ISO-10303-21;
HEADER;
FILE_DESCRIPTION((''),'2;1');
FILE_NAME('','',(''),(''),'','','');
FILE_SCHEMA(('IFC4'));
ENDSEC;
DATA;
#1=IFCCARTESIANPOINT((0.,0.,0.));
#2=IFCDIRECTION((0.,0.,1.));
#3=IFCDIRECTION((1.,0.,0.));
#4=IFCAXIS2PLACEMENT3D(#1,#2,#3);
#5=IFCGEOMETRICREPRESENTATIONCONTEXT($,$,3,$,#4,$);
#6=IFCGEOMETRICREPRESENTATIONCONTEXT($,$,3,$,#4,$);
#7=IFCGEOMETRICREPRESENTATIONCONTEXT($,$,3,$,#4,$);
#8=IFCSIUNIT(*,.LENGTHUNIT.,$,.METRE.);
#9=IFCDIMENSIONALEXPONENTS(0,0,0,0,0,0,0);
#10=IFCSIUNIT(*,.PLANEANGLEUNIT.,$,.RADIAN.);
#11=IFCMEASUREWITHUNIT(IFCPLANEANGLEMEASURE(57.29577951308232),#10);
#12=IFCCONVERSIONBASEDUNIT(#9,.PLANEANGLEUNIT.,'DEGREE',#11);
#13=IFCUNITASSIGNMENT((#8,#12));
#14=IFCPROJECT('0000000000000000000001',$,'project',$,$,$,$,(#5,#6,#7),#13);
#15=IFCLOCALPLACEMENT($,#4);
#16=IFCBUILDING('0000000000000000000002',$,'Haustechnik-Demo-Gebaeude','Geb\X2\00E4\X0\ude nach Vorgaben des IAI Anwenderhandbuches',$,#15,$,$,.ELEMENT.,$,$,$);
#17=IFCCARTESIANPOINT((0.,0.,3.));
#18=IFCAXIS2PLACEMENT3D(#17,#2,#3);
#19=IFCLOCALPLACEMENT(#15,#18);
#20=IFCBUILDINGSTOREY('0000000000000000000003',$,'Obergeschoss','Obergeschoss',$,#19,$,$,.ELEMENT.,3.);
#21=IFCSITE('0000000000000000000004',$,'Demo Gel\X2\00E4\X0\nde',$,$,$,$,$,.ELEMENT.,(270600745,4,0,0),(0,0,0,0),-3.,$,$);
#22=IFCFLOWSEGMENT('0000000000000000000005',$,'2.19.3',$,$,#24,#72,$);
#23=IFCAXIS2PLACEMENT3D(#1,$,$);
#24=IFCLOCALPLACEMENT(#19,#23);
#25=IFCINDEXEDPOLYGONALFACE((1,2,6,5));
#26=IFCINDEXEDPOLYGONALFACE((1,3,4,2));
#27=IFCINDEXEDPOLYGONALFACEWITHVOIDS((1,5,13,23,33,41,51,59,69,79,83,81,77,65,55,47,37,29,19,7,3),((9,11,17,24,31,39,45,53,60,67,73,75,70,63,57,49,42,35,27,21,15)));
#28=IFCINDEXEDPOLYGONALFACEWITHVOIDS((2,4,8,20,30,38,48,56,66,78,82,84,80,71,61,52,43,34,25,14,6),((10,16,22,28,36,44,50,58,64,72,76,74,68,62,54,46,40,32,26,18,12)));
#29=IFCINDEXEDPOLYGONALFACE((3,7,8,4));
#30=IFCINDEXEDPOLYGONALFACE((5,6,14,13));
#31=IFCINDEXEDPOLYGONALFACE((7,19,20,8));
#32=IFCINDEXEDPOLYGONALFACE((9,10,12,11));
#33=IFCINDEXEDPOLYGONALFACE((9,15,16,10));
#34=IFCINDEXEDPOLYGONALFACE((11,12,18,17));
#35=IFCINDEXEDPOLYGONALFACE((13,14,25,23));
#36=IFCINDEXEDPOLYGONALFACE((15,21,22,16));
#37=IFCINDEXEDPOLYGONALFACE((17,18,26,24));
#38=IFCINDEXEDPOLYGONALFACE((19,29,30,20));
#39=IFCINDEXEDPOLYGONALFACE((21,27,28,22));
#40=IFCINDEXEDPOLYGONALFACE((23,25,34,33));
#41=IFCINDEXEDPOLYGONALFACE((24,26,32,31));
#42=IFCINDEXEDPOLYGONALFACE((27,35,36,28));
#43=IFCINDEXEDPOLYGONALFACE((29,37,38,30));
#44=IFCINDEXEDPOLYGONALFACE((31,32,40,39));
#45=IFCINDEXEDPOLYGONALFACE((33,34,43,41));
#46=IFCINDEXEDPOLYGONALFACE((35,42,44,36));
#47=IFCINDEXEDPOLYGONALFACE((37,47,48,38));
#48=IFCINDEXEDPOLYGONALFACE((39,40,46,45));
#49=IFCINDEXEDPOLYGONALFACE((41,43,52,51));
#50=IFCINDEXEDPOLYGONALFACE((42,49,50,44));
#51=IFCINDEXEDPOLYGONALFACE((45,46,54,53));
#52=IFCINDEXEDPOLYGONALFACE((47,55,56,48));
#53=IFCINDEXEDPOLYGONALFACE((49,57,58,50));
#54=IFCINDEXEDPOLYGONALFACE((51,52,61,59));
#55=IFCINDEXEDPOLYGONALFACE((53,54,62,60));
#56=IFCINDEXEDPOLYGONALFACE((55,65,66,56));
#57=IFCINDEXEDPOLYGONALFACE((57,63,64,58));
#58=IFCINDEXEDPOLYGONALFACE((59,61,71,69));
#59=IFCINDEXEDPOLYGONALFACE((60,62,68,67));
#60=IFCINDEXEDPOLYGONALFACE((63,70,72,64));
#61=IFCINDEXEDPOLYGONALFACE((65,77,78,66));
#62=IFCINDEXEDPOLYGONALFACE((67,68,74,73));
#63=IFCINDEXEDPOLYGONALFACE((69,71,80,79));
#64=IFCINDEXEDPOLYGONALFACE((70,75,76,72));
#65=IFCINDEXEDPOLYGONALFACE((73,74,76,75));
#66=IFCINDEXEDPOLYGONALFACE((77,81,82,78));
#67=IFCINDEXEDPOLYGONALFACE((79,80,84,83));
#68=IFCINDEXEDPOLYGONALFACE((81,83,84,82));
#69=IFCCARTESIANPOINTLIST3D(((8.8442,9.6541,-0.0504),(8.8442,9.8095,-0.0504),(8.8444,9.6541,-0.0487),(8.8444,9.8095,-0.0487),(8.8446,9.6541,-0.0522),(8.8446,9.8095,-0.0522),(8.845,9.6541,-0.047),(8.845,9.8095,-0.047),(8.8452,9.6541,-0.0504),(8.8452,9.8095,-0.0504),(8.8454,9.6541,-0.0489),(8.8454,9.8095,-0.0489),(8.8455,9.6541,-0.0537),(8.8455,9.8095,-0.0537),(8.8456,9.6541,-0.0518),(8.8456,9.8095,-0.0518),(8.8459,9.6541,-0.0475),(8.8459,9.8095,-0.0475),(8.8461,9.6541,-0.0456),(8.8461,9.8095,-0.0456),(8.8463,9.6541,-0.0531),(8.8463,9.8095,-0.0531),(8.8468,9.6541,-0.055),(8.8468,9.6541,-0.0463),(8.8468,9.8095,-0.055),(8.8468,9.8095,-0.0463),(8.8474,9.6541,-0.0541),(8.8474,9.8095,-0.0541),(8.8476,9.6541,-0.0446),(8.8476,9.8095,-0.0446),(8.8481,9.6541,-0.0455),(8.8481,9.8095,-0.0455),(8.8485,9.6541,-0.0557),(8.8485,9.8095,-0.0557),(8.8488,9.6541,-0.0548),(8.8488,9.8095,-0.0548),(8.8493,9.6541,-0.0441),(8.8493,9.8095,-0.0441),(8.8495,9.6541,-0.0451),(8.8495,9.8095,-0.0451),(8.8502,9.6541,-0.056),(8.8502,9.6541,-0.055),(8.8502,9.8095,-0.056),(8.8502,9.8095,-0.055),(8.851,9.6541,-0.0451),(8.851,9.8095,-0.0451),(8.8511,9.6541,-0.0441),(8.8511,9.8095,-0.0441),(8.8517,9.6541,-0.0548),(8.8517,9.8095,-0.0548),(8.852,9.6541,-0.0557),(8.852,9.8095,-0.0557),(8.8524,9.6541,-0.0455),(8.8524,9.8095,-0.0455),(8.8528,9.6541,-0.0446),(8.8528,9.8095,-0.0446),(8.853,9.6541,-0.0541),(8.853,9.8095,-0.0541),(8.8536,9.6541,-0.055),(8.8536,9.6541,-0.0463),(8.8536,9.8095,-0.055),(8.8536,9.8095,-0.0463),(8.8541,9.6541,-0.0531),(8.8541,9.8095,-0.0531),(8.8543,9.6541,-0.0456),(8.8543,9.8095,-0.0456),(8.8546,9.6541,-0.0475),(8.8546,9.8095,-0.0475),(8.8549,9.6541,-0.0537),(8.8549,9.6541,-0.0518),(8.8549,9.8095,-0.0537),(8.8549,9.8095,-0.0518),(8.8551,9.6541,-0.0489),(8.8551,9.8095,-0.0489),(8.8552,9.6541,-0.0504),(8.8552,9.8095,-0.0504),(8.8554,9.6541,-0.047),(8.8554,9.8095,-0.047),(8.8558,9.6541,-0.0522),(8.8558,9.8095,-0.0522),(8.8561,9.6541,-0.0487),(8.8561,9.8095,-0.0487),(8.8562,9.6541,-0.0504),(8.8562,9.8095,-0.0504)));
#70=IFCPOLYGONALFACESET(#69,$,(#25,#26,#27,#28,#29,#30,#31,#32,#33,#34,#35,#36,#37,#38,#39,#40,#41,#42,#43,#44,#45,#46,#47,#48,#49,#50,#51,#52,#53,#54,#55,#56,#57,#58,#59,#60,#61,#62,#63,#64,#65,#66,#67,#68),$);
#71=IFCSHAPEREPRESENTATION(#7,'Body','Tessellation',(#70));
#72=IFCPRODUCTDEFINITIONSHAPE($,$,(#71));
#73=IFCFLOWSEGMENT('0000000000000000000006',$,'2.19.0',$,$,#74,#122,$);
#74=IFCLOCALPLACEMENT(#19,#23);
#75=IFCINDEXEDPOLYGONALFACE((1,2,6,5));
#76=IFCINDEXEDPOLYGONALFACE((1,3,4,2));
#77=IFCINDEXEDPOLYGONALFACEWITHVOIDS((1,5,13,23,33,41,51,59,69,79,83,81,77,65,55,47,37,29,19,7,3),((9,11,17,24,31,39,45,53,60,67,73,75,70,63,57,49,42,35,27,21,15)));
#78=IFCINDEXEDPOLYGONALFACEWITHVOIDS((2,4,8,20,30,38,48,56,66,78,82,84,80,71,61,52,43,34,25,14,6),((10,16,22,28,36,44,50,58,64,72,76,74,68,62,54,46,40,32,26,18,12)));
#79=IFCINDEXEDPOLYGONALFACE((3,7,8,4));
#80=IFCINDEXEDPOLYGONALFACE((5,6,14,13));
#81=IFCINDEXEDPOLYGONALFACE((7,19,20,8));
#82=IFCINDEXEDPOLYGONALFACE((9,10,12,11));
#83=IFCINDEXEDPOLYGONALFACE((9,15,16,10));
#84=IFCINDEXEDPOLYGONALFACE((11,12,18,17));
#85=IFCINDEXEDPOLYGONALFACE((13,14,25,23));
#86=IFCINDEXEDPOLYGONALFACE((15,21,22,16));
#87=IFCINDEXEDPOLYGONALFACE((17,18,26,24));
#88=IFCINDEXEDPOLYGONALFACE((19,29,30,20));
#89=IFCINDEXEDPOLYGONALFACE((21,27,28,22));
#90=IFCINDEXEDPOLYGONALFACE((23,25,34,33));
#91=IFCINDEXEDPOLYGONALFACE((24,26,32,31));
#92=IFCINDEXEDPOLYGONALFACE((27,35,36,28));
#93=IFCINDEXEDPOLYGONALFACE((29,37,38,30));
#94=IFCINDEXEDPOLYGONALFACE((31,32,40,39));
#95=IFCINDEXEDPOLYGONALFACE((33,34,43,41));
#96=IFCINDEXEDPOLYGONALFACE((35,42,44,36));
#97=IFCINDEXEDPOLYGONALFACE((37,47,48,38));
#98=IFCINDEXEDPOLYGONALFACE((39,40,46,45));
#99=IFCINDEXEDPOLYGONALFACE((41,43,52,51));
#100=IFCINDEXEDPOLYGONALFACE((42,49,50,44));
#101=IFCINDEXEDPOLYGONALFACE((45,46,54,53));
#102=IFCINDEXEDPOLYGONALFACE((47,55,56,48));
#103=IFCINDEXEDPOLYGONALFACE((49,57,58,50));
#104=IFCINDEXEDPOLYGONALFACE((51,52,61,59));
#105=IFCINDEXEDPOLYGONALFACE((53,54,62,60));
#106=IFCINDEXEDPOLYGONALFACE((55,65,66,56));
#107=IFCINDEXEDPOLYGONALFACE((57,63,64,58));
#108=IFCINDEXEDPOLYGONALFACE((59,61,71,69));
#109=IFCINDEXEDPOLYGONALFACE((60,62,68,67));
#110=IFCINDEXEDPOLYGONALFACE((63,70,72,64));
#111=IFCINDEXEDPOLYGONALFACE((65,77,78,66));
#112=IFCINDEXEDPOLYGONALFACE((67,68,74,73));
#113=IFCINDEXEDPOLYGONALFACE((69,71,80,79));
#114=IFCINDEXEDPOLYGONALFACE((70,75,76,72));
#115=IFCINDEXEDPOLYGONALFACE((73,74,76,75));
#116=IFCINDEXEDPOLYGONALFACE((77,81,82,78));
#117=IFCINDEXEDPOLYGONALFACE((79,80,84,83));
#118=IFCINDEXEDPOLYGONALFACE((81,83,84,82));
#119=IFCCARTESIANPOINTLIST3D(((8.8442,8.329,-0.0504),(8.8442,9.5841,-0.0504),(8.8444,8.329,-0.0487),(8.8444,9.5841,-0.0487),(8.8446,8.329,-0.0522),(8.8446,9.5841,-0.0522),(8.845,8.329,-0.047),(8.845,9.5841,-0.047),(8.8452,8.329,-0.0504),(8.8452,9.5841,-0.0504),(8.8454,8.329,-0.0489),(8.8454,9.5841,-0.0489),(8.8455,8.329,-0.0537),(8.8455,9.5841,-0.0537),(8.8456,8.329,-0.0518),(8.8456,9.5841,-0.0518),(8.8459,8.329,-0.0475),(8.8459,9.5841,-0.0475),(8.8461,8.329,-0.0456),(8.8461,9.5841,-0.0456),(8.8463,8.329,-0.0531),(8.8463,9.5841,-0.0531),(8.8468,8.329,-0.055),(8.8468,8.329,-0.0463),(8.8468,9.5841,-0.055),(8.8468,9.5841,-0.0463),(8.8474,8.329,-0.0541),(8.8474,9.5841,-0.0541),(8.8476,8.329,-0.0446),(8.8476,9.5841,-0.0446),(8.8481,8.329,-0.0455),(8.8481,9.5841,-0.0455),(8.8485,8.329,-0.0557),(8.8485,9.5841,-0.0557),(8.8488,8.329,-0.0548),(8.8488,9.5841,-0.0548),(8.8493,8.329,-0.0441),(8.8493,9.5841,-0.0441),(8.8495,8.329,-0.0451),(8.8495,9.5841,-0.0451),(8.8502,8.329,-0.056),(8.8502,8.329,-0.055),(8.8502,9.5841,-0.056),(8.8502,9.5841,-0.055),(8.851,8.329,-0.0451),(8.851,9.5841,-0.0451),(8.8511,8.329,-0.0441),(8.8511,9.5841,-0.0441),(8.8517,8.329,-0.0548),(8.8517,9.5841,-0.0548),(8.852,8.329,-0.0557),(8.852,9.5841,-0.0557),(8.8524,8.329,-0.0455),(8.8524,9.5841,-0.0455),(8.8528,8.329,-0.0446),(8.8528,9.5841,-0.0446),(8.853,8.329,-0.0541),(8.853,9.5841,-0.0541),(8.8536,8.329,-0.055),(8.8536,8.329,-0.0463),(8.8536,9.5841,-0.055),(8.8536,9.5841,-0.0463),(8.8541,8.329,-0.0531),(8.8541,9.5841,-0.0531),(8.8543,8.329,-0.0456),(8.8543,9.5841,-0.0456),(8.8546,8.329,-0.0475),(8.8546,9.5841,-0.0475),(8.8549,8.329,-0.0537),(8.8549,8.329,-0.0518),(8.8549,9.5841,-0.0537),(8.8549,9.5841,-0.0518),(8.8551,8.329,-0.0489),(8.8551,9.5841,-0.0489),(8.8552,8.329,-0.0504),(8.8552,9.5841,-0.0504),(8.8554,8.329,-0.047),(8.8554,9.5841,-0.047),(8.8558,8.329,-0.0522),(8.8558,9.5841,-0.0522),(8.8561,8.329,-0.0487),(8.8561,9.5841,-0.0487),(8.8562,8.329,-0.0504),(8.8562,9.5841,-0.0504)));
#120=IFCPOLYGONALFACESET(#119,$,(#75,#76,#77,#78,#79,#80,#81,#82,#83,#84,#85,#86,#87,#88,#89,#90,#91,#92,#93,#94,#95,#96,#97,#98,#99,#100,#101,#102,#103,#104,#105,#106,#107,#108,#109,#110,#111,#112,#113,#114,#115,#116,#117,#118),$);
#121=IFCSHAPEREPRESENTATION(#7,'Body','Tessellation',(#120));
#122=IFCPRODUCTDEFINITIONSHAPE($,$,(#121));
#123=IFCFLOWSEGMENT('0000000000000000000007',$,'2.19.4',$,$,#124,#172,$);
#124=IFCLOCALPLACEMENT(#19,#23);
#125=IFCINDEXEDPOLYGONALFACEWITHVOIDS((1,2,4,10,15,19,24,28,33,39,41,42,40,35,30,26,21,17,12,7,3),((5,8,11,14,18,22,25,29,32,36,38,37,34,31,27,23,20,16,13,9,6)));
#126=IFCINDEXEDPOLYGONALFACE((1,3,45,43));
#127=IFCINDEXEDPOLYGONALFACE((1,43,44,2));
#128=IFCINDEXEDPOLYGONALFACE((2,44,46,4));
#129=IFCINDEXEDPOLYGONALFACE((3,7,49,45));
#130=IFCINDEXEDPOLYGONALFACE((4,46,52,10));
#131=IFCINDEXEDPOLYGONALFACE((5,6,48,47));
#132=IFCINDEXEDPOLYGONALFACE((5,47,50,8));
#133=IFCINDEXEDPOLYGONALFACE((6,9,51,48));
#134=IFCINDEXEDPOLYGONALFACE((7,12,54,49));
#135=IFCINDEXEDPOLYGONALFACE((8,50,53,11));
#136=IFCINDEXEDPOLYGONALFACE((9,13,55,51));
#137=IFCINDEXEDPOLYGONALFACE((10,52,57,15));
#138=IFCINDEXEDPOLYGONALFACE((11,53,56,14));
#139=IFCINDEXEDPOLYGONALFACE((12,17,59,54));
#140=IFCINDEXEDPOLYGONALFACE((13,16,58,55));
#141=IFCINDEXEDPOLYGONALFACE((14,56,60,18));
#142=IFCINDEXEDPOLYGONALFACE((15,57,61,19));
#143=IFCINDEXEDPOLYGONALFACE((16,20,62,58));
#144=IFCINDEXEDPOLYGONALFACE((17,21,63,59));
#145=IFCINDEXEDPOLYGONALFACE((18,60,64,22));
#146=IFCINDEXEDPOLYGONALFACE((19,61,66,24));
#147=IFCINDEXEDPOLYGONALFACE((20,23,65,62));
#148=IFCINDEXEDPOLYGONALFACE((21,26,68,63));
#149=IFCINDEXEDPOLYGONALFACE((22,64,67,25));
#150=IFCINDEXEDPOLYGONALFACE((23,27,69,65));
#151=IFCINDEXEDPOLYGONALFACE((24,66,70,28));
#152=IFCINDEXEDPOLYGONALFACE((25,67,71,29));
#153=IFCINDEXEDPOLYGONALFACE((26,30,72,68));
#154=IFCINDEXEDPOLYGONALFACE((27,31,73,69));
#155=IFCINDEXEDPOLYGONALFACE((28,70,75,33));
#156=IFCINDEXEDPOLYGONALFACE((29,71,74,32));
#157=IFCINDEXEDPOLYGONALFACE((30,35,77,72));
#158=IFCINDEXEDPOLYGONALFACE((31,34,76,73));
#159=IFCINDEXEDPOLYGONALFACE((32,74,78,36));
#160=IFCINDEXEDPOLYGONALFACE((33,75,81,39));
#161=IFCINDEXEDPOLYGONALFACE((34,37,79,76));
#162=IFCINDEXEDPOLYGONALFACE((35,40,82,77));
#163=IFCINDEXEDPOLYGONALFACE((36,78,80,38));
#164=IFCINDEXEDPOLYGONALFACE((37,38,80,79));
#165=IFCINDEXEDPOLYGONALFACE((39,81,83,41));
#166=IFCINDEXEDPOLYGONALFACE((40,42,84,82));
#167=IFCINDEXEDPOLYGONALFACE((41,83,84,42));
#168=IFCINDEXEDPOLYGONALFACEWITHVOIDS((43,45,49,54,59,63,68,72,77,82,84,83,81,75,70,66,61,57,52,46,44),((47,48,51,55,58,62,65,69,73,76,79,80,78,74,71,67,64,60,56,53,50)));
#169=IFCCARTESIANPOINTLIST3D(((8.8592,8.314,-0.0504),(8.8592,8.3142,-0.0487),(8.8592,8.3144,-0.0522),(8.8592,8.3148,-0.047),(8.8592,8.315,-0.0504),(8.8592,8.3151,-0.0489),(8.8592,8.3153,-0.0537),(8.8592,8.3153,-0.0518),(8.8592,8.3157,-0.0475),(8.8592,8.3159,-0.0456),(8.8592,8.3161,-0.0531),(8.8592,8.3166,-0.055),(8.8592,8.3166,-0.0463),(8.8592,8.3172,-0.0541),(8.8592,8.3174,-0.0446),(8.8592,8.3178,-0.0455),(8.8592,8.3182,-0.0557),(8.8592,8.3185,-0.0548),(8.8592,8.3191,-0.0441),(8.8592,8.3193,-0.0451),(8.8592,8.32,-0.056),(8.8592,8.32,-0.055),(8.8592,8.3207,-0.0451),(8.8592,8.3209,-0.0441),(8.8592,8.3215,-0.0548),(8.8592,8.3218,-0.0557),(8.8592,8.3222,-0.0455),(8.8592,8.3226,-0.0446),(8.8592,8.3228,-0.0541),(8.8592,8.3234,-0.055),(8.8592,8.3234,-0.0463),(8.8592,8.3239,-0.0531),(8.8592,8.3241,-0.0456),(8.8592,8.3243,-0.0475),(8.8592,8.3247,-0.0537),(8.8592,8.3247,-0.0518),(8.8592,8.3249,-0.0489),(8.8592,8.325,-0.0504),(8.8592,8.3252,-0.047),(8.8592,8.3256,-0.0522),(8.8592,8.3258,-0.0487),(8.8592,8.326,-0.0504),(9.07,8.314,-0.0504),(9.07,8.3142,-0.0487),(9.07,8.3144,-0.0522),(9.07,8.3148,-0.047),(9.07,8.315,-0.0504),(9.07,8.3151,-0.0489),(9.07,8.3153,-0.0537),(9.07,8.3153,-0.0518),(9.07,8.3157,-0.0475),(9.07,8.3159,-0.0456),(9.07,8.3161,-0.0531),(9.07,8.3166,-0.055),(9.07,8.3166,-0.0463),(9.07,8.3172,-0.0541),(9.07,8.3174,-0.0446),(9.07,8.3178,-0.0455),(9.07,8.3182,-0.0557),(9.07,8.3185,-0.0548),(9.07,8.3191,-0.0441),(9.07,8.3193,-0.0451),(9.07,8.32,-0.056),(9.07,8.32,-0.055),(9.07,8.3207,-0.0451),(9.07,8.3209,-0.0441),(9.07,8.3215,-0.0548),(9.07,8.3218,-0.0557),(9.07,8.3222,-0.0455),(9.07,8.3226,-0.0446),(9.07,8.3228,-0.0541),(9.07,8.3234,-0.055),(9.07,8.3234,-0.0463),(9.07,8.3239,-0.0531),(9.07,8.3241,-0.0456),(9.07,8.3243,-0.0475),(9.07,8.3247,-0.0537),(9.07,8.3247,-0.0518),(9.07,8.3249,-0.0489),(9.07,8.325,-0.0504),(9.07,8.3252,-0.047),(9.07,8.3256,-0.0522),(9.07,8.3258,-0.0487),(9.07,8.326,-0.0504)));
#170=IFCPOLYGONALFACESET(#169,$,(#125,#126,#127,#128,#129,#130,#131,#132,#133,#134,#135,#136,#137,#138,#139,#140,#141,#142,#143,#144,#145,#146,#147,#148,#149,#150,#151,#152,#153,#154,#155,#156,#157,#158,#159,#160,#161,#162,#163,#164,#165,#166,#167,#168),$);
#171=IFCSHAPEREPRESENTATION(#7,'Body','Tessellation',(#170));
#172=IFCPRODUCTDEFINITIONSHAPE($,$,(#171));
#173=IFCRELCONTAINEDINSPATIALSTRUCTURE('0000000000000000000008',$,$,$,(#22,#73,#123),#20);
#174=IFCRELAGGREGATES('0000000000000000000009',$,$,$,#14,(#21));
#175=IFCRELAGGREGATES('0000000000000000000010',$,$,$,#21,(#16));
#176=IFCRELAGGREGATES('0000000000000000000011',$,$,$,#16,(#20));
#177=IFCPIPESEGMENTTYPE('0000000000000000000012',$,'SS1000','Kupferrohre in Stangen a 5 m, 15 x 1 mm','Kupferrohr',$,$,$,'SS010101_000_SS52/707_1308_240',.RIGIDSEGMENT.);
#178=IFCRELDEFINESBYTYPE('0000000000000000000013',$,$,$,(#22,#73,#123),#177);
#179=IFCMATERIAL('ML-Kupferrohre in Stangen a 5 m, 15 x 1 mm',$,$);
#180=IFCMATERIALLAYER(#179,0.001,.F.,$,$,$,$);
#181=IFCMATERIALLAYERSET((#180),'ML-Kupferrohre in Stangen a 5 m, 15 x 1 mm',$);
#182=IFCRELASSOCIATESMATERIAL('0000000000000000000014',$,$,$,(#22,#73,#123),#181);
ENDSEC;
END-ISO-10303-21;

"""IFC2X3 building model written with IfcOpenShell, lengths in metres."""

from ifc_helpers import new_model, entity, si_unit, converted_unit, frame, origin_with_axes, origin_2d_with_axis, place, context, project, spatial, hollow_circle, extrude, material, layer, layer_set, layer_usage, type_object, element, save


model = new_model("IFC2X3")

# Units and contexts
context_of_model_1 = context(None, 3, world=origin_with_axes())
context_of_model_2 = context(None, 3, world=origin_with_axes())
context_of_model_3 = context(None, 3, world=origin_with_axes())
ifc_project = project(units=[si_unit("LENGTHUNIT", "METRE"), converted_unit("PLANEANGLEUNIT", "DEGREE", entity("IfcPlaneAngleMeasure", 57.29577951308232), si_unit("PLANEANGLEUNIT", "RADIAN"), dimensions=[0, 0, 0, 0, 0, 0, 0])], contexts=[context_of_model_1, context_of_model_2, context_of_model_3])

# Site, building, storey
site = spatial("IfcSite", under=ifc_project, Name="Demo Gelände", CompositionType="ELEMENT", RefLatitude=(270600745, 4, 0, 0), RefLongitude=(0, 0, 0, 0), RefElevation=-3.0)
building_placement = place(None, origin_with_axes())
building = spatial("IfcBuilding", under=site, at=building_placement, Name="Haustechnik-Demo-Gebaeude", Description="Gebäude nach Vorgaben des IAI Anwenderhandbuches", CompositionType="ELEMENT")
storey_placement = place(building_placement, frame((0.0, 0.0, 3.0), z_axis=(0.0, 0.0, 1.0), x_axis=(1.0, 0.0, 0.0)))
storey = spatial("IfcBuildingStorey", under=building, at=storey_placement, Name="Obergeschoss", Description="Obergeschoss", CompositionType="ELEMENT", Elevation=3.0)

# Flow segments
ifc_material_1 = material(Name="ML-Kupferrohre in Stangen a 5 m, 15 x 1 mm")
ifc_layer_1 = layer(ifc_material_1, 0.001, ventilated=False)
ifc_layer_set_1 = layer_set([ifc_layer_1], Name="ML-Kupferrohre in Stangen a 5 m, 15 x 1 mm")
ifc_layer_usage_1 = layer_usage(ifc_layer_set_1, "AXIS2", "POSITIVE", 0.0)
pipe_segment_type_1 = type_object("IfcPipeSegmentType", Name="SS1000", Description="Kupferrohre in Stangen a 5 m, 15 x 1 mm", ApplicableOccurrence="Kupferrohr", ElementType="SS010101_000_SS52/707_1308_240", PredefinedType="RIGIDSEGMENT")
flow_segment_1_placement = place(storey_placement, frame((8.8502, 9.8095, -0.05), z_axis=(0.0, -1.0, 0.0), x_axis=(0.0, 0.0, -1.0)))
element("IfcFlowSegment", 1, at=flow_segment_1_placement, inside=storey, type_object=pipe_segment_type_1, material=ifc_layer_usage_1, Name="2.19.3", context=context_of_model_3, shape_type="SweptSolid", body=[
    extrude(hollow_circle(Radius=0.006, WallThickness=0.001, at=origin_2d_with_axis()), origin_with_axes(), (0.0, 0.0, 1.0), 0.1554),
])
flow_segment_2_placement = place(storey_placement, frame((8.8502, 9.5841, -0.05), z_axis=(0.0, -1.0, 0.0), x_axis=(0.0, 0.0, -1.0)))
element("IfcFlowSegment", 2, at=flow_segment_2_placement, inside=storey, type_object=pipe_segment_type_1, material=ifc_layer_usage_1, Name="2.19.0", context=context_of_model_3, shape_type="SweptSolid", body=[
    extrude(hollow_circle(Radius=0.006, WallThickness=0.001, at=origin_2d_with_axis()), origin_with_axes(), (0.0, 0.0, 1.0), 1.2551),
])
flow_segment_3_placement = place(storey_placement, frame((8.8592, 8.32, -0.05), z_axis=(1.0, 0.0, 0.0), x_axis=(0.0, 0.0, -1.0)))
element("IfcFlowSegment", 3, at=flow_segment_3_placement, inside=storey, type_object=pipe_segment_type_1, material=ifc_layer_usage_1, Name="2.19.4", context=context_of_model_3, shape_type="SweptSolid", body=[
    extrude(hollow_circle(Radius=0.006, WallThickness=0.001, at=origin_2d_with_axis()), origin_with_axes(), (0.0, 0.0, 1.0), 0.2108),
])

save(model, "model.ifc")
